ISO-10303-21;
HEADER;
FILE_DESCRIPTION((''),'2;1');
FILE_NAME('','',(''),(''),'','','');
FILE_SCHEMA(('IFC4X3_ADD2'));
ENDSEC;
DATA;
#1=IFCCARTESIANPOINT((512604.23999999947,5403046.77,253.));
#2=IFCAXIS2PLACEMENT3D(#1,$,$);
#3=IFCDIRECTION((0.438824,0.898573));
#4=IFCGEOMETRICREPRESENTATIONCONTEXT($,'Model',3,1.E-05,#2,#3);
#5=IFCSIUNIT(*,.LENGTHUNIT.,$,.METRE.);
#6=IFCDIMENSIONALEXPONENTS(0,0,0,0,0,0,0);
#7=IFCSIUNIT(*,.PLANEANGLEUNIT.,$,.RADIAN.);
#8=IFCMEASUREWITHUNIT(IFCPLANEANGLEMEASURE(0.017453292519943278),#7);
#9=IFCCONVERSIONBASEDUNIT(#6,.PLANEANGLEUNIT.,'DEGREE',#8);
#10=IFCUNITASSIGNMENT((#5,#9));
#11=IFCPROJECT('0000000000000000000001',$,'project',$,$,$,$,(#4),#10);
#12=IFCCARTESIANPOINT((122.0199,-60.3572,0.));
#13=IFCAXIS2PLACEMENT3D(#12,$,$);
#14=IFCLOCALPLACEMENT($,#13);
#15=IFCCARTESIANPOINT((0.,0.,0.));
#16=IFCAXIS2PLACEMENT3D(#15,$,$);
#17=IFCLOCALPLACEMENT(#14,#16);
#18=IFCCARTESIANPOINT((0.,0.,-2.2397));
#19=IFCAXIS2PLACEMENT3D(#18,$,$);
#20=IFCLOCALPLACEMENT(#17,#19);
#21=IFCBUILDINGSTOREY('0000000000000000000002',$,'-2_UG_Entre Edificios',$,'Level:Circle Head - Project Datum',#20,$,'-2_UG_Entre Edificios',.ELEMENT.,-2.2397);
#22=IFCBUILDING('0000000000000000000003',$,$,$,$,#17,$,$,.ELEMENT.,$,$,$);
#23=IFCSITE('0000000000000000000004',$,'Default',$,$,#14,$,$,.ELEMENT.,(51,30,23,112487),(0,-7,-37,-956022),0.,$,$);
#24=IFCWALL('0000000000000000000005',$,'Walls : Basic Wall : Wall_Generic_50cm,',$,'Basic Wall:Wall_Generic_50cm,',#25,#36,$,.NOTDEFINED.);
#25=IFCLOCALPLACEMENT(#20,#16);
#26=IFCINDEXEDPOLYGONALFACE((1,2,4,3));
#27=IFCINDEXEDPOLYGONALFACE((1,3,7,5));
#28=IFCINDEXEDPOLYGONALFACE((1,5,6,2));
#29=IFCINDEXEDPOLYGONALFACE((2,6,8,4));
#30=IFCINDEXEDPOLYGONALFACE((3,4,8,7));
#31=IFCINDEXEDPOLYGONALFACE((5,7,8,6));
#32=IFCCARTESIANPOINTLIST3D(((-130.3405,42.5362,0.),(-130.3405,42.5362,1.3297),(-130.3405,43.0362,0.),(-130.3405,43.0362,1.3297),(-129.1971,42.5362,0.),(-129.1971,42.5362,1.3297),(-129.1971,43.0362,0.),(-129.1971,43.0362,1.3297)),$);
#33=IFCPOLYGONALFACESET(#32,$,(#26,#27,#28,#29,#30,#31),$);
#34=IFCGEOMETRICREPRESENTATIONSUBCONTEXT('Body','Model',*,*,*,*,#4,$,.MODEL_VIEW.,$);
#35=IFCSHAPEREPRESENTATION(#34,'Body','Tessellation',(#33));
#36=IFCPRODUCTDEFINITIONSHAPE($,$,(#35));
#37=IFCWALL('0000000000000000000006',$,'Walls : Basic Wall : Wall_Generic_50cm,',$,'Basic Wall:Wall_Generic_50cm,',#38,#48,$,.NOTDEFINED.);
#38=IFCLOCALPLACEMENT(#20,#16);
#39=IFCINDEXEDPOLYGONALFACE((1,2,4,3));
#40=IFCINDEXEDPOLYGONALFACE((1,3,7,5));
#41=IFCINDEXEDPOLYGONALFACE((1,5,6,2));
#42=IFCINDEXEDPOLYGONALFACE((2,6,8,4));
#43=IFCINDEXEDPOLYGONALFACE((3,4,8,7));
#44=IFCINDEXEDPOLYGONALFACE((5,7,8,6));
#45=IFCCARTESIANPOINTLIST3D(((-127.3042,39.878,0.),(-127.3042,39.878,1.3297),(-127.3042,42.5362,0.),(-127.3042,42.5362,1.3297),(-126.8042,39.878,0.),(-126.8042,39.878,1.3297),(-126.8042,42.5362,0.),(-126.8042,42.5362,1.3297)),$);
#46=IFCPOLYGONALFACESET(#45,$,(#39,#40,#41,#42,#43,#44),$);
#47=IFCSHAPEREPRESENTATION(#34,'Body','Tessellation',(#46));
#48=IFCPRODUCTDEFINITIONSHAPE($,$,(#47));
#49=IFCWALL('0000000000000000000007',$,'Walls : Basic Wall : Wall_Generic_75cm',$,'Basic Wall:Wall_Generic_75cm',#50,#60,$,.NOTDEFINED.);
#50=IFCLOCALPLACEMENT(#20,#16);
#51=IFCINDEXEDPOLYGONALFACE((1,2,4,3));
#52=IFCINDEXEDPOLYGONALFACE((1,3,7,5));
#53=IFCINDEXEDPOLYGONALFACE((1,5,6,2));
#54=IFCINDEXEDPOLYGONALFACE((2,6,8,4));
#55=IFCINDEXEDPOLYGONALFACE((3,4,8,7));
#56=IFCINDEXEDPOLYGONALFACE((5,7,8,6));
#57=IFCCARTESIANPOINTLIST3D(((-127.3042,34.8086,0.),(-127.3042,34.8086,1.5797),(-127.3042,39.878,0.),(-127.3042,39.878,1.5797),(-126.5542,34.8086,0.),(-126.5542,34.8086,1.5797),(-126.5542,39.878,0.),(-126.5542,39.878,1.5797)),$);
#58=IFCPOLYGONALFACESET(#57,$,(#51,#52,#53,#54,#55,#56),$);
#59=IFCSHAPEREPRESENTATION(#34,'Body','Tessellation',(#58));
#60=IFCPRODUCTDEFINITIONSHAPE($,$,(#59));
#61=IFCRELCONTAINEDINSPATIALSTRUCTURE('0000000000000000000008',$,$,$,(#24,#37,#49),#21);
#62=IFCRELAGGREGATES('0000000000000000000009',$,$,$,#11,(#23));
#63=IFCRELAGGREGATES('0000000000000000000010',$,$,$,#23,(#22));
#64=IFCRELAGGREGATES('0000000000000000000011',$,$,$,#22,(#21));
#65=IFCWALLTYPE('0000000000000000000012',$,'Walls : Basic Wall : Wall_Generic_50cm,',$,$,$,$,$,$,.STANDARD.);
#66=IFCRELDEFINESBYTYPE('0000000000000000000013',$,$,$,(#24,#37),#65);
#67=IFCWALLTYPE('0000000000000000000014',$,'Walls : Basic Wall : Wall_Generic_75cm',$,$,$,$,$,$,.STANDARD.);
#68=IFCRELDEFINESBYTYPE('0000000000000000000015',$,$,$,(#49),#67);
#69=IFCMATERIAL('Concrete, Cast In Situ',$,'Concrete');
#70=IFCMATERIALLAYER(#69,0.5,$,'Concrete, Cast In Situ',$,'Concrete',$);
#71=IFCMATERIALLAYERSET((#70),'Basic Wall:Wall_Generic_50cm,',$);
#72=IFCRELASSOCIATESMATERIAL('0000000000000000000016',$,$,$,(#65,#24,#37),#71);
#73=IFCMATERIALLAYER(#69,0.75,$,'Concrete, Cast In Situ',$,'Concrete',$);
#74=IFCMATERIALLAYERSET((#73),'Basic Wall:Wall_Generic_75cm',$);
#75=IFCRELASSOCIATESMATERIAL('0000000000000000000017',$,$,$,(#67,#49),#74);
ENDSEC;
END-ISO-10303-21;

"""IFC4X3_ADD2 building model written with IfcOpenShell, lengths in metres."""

from ifc_helpers import new_model, entity, si_unit, converted_unit, direction, frame, frame_2d, origin, place, context, subcontext, project, spatial, polyline, rectangle, extrude, clip, halfspace, bounded_halfspace, material, layer, layer_set, type_object, element, save


model = new_model("IFC4X3_ADD2")

# Units and contexts
model_context = context("Model", 3, precision=1e-05, world=frame((512604.23999999947, 5403046.77, 253.0)), true_north=direction((0.438824, 0.898573)))
body_context = subcontext(model_context, "Body", "Model", "MODEL_VIEW")
ifc_project = project(units=[si_unit("LENGTHUNIT", "METRE"), converted_unit("PLANEANGLEUNIT", "DEGREE", entity("IfcPlaneAngleMeasure", 0.017453292519943278), si_unit("PLANEANGLEUNIT", "RADIAN"), dimensions=[0, 0, 0, 0, 0, 0, 0])], contexts=[model_context])

# Site, building, storey
site_placement = place(None, frame((122.0199, -60.3572, 0.0)))
site = spatial("IfcSite", under=ifc_project, at=site_placement, Name="Default", CompositionType="ELEMENT", RefLatitude=(51, 30, 23, 112487), RefLongitude=(0, -7, -37, -956022), RefElevation=0.0)
building_placement = place(site_placement, origin())
building = spatial("IfcBuilding", under=site, at=building_placement, CompositionType="ELEMENT")
storey_placement = place(building_placement, frame((0.0, 0.0, -2.2397)))
storey = spatial("IfcBuildingStorey", under=building, at=storey_placement, Name="-2_UG_Entre Edificios", ObjectType="Level:Circle Head - Project Datum", LongName="-2_UG_Entre Edificios", CompositionType="ELEMENT", Elevation=-2.2397)

# Shared definitions
ifc_material_1 = material(Name="Concrete, Cast In Situ", Category="Concrete")

# Walls
ifc_layer_1 = layer(ifc_material_1, 0.5, Name="Concrete, Cast In Situ", Category="Concrete")
ifc_layer_set_1 = layer_set([ifc_layer_1], Name="Basic Wall:Wall_Generic_50cm,")
wall_type_1 = type_object("IfcWallType", Name="Walls : Basic Wall : Wall_Generic_50cm,", PredefinedType="STANDARD", material=ifc_layer_set_1)
wall_1_placement = place(storey_placement, frame((-129.1971, 42.7862, 0.0), z_axis=(0.0, 0.0, 1.0), x_axis=(-1.0, 0.0, 0.0)))
element("IfcWall", 1, at=wall_1_placement, inside=storey, type_object=wall_type_1, material=ifc_layer_set_1, Name="Walls : Basic Wall : Wall_Generic_50cm,", ObjectType="Basic Wall:Wall_Generic_50cm,", PredefinedType="NOTDEFINED", context=body_context, shape_type="Clipping", body=[
    clip(clip(extrude(rectangle(XDim=1.1434, YDim=0.5, at=frame_2d((0.5717, 0.0), x_axis=(-1.0, 0.0))), origin(), (0.0, 0.0, 1.0), 1.3297), bounded_halfspace(frame((0.0, -0.25, 1.3297), z_axis=(0.0, 0.0, -1.0), x_axis=(-1.0, 0.0, 0.0)), True, frame((0.0, -0.25, 1.3297)), polyline([(0.0, 0.0), (1.1434, 0.0), (1.1434, 0.0071), (1.1434, 0.4071), (1.1434, 0.5), (0.3434, 0.5), (0.1434, 0.5), (0.0, 0.5), (0.0, 0.36), (0.0, 0.0)]))), halfspace(frame((0.0, 0.0, -1.0603)), True)),
])
wall_2_placement = place(storey_placement, frame((-127.0542, 42.5362, 0.0), z_axis=(0.0, 0.0, 1.0), x_axis=(0.0, -1.0, 0.0)))
element("IfcWall", 2, at=wall_2_placement, inside=storey, type_object=wall_type_1, material=ifc_layer_set_1, Name="Walls : Basic Wall : Wall_Generic_50cm,", ObjectType="Basic Wall:Wall_Generic_50cm,", PredefinedType="NOTDEFINED", context=body_context, shape_type="Clipping", body=[
    clip(clip(extrude(rectangle(XDim=2.6582, YDim=0.5, at=frame_2d((1.3291, 0.0), x_axis=(-1.0, 0.0))), origin(), (0.0, 0.0, 1.0), 1.3297), bounded_halfspace(frame((0.0, -0.25, 1.3297), z_axis=(0.0, 0.0, -1.0), x_axis=(0.0, 1.0, 0.0)), True, frame((0.0, -0.25, 1.3297)), polyline([(0.0, 0.0), (2.6582, 0.0), (2.6582, 0.5), (0.0, 0.5), (0.0, 0.0)]))), halfspace(frame((0.0, 0.0, -1.0603)), True)),
])
ifc_layer_2 = layer(ifc_material_1, 0.75, Name="Concrete, Cast In Situ", Category="Concrete")
ifc_layer_set_2 = layer_set([ifc_layer_2], Name="Basic Wall:Wall_Generic_75cm")
wall_type_2 = type_object("IfcWallType", Name="Walls : Basic Wall : Wall_Generic_75cm", PredefinedType="STANDARD", material=ifc_layer_set_2)
wall_3_placement = place(storey_placement, frame((-126.9292, 39.878, 0.0), z_axis=(0.0, 0.0, 1.0), x_axis=(0.0, -1.0, 0.0)))
element("IfcWall", 3, at=wall_3_placement, inside=storey, type_object=wall_type_2, material=ifc_layer_set_2, Name="Walls : Basic Wall : Wall_Generic_75cm", ObjectType="Basic Wall:Wall_Generic_75cm", PredefinedType="NOTDEFINED", context=body_context, shape_type="Clipping", body=[
    clip(extrude(rectangle(XDim=5.0695, YDim=0.75, at=frame_2d((2.5347, 0.0), x_axis=(-1.0, 0.0))), origin(), (0.0, 0.0, 1.0), 1.5797), halfspace(frame((0.0, 0.0, -1.0603)), True)),
])

save(model, "model.ifc")
